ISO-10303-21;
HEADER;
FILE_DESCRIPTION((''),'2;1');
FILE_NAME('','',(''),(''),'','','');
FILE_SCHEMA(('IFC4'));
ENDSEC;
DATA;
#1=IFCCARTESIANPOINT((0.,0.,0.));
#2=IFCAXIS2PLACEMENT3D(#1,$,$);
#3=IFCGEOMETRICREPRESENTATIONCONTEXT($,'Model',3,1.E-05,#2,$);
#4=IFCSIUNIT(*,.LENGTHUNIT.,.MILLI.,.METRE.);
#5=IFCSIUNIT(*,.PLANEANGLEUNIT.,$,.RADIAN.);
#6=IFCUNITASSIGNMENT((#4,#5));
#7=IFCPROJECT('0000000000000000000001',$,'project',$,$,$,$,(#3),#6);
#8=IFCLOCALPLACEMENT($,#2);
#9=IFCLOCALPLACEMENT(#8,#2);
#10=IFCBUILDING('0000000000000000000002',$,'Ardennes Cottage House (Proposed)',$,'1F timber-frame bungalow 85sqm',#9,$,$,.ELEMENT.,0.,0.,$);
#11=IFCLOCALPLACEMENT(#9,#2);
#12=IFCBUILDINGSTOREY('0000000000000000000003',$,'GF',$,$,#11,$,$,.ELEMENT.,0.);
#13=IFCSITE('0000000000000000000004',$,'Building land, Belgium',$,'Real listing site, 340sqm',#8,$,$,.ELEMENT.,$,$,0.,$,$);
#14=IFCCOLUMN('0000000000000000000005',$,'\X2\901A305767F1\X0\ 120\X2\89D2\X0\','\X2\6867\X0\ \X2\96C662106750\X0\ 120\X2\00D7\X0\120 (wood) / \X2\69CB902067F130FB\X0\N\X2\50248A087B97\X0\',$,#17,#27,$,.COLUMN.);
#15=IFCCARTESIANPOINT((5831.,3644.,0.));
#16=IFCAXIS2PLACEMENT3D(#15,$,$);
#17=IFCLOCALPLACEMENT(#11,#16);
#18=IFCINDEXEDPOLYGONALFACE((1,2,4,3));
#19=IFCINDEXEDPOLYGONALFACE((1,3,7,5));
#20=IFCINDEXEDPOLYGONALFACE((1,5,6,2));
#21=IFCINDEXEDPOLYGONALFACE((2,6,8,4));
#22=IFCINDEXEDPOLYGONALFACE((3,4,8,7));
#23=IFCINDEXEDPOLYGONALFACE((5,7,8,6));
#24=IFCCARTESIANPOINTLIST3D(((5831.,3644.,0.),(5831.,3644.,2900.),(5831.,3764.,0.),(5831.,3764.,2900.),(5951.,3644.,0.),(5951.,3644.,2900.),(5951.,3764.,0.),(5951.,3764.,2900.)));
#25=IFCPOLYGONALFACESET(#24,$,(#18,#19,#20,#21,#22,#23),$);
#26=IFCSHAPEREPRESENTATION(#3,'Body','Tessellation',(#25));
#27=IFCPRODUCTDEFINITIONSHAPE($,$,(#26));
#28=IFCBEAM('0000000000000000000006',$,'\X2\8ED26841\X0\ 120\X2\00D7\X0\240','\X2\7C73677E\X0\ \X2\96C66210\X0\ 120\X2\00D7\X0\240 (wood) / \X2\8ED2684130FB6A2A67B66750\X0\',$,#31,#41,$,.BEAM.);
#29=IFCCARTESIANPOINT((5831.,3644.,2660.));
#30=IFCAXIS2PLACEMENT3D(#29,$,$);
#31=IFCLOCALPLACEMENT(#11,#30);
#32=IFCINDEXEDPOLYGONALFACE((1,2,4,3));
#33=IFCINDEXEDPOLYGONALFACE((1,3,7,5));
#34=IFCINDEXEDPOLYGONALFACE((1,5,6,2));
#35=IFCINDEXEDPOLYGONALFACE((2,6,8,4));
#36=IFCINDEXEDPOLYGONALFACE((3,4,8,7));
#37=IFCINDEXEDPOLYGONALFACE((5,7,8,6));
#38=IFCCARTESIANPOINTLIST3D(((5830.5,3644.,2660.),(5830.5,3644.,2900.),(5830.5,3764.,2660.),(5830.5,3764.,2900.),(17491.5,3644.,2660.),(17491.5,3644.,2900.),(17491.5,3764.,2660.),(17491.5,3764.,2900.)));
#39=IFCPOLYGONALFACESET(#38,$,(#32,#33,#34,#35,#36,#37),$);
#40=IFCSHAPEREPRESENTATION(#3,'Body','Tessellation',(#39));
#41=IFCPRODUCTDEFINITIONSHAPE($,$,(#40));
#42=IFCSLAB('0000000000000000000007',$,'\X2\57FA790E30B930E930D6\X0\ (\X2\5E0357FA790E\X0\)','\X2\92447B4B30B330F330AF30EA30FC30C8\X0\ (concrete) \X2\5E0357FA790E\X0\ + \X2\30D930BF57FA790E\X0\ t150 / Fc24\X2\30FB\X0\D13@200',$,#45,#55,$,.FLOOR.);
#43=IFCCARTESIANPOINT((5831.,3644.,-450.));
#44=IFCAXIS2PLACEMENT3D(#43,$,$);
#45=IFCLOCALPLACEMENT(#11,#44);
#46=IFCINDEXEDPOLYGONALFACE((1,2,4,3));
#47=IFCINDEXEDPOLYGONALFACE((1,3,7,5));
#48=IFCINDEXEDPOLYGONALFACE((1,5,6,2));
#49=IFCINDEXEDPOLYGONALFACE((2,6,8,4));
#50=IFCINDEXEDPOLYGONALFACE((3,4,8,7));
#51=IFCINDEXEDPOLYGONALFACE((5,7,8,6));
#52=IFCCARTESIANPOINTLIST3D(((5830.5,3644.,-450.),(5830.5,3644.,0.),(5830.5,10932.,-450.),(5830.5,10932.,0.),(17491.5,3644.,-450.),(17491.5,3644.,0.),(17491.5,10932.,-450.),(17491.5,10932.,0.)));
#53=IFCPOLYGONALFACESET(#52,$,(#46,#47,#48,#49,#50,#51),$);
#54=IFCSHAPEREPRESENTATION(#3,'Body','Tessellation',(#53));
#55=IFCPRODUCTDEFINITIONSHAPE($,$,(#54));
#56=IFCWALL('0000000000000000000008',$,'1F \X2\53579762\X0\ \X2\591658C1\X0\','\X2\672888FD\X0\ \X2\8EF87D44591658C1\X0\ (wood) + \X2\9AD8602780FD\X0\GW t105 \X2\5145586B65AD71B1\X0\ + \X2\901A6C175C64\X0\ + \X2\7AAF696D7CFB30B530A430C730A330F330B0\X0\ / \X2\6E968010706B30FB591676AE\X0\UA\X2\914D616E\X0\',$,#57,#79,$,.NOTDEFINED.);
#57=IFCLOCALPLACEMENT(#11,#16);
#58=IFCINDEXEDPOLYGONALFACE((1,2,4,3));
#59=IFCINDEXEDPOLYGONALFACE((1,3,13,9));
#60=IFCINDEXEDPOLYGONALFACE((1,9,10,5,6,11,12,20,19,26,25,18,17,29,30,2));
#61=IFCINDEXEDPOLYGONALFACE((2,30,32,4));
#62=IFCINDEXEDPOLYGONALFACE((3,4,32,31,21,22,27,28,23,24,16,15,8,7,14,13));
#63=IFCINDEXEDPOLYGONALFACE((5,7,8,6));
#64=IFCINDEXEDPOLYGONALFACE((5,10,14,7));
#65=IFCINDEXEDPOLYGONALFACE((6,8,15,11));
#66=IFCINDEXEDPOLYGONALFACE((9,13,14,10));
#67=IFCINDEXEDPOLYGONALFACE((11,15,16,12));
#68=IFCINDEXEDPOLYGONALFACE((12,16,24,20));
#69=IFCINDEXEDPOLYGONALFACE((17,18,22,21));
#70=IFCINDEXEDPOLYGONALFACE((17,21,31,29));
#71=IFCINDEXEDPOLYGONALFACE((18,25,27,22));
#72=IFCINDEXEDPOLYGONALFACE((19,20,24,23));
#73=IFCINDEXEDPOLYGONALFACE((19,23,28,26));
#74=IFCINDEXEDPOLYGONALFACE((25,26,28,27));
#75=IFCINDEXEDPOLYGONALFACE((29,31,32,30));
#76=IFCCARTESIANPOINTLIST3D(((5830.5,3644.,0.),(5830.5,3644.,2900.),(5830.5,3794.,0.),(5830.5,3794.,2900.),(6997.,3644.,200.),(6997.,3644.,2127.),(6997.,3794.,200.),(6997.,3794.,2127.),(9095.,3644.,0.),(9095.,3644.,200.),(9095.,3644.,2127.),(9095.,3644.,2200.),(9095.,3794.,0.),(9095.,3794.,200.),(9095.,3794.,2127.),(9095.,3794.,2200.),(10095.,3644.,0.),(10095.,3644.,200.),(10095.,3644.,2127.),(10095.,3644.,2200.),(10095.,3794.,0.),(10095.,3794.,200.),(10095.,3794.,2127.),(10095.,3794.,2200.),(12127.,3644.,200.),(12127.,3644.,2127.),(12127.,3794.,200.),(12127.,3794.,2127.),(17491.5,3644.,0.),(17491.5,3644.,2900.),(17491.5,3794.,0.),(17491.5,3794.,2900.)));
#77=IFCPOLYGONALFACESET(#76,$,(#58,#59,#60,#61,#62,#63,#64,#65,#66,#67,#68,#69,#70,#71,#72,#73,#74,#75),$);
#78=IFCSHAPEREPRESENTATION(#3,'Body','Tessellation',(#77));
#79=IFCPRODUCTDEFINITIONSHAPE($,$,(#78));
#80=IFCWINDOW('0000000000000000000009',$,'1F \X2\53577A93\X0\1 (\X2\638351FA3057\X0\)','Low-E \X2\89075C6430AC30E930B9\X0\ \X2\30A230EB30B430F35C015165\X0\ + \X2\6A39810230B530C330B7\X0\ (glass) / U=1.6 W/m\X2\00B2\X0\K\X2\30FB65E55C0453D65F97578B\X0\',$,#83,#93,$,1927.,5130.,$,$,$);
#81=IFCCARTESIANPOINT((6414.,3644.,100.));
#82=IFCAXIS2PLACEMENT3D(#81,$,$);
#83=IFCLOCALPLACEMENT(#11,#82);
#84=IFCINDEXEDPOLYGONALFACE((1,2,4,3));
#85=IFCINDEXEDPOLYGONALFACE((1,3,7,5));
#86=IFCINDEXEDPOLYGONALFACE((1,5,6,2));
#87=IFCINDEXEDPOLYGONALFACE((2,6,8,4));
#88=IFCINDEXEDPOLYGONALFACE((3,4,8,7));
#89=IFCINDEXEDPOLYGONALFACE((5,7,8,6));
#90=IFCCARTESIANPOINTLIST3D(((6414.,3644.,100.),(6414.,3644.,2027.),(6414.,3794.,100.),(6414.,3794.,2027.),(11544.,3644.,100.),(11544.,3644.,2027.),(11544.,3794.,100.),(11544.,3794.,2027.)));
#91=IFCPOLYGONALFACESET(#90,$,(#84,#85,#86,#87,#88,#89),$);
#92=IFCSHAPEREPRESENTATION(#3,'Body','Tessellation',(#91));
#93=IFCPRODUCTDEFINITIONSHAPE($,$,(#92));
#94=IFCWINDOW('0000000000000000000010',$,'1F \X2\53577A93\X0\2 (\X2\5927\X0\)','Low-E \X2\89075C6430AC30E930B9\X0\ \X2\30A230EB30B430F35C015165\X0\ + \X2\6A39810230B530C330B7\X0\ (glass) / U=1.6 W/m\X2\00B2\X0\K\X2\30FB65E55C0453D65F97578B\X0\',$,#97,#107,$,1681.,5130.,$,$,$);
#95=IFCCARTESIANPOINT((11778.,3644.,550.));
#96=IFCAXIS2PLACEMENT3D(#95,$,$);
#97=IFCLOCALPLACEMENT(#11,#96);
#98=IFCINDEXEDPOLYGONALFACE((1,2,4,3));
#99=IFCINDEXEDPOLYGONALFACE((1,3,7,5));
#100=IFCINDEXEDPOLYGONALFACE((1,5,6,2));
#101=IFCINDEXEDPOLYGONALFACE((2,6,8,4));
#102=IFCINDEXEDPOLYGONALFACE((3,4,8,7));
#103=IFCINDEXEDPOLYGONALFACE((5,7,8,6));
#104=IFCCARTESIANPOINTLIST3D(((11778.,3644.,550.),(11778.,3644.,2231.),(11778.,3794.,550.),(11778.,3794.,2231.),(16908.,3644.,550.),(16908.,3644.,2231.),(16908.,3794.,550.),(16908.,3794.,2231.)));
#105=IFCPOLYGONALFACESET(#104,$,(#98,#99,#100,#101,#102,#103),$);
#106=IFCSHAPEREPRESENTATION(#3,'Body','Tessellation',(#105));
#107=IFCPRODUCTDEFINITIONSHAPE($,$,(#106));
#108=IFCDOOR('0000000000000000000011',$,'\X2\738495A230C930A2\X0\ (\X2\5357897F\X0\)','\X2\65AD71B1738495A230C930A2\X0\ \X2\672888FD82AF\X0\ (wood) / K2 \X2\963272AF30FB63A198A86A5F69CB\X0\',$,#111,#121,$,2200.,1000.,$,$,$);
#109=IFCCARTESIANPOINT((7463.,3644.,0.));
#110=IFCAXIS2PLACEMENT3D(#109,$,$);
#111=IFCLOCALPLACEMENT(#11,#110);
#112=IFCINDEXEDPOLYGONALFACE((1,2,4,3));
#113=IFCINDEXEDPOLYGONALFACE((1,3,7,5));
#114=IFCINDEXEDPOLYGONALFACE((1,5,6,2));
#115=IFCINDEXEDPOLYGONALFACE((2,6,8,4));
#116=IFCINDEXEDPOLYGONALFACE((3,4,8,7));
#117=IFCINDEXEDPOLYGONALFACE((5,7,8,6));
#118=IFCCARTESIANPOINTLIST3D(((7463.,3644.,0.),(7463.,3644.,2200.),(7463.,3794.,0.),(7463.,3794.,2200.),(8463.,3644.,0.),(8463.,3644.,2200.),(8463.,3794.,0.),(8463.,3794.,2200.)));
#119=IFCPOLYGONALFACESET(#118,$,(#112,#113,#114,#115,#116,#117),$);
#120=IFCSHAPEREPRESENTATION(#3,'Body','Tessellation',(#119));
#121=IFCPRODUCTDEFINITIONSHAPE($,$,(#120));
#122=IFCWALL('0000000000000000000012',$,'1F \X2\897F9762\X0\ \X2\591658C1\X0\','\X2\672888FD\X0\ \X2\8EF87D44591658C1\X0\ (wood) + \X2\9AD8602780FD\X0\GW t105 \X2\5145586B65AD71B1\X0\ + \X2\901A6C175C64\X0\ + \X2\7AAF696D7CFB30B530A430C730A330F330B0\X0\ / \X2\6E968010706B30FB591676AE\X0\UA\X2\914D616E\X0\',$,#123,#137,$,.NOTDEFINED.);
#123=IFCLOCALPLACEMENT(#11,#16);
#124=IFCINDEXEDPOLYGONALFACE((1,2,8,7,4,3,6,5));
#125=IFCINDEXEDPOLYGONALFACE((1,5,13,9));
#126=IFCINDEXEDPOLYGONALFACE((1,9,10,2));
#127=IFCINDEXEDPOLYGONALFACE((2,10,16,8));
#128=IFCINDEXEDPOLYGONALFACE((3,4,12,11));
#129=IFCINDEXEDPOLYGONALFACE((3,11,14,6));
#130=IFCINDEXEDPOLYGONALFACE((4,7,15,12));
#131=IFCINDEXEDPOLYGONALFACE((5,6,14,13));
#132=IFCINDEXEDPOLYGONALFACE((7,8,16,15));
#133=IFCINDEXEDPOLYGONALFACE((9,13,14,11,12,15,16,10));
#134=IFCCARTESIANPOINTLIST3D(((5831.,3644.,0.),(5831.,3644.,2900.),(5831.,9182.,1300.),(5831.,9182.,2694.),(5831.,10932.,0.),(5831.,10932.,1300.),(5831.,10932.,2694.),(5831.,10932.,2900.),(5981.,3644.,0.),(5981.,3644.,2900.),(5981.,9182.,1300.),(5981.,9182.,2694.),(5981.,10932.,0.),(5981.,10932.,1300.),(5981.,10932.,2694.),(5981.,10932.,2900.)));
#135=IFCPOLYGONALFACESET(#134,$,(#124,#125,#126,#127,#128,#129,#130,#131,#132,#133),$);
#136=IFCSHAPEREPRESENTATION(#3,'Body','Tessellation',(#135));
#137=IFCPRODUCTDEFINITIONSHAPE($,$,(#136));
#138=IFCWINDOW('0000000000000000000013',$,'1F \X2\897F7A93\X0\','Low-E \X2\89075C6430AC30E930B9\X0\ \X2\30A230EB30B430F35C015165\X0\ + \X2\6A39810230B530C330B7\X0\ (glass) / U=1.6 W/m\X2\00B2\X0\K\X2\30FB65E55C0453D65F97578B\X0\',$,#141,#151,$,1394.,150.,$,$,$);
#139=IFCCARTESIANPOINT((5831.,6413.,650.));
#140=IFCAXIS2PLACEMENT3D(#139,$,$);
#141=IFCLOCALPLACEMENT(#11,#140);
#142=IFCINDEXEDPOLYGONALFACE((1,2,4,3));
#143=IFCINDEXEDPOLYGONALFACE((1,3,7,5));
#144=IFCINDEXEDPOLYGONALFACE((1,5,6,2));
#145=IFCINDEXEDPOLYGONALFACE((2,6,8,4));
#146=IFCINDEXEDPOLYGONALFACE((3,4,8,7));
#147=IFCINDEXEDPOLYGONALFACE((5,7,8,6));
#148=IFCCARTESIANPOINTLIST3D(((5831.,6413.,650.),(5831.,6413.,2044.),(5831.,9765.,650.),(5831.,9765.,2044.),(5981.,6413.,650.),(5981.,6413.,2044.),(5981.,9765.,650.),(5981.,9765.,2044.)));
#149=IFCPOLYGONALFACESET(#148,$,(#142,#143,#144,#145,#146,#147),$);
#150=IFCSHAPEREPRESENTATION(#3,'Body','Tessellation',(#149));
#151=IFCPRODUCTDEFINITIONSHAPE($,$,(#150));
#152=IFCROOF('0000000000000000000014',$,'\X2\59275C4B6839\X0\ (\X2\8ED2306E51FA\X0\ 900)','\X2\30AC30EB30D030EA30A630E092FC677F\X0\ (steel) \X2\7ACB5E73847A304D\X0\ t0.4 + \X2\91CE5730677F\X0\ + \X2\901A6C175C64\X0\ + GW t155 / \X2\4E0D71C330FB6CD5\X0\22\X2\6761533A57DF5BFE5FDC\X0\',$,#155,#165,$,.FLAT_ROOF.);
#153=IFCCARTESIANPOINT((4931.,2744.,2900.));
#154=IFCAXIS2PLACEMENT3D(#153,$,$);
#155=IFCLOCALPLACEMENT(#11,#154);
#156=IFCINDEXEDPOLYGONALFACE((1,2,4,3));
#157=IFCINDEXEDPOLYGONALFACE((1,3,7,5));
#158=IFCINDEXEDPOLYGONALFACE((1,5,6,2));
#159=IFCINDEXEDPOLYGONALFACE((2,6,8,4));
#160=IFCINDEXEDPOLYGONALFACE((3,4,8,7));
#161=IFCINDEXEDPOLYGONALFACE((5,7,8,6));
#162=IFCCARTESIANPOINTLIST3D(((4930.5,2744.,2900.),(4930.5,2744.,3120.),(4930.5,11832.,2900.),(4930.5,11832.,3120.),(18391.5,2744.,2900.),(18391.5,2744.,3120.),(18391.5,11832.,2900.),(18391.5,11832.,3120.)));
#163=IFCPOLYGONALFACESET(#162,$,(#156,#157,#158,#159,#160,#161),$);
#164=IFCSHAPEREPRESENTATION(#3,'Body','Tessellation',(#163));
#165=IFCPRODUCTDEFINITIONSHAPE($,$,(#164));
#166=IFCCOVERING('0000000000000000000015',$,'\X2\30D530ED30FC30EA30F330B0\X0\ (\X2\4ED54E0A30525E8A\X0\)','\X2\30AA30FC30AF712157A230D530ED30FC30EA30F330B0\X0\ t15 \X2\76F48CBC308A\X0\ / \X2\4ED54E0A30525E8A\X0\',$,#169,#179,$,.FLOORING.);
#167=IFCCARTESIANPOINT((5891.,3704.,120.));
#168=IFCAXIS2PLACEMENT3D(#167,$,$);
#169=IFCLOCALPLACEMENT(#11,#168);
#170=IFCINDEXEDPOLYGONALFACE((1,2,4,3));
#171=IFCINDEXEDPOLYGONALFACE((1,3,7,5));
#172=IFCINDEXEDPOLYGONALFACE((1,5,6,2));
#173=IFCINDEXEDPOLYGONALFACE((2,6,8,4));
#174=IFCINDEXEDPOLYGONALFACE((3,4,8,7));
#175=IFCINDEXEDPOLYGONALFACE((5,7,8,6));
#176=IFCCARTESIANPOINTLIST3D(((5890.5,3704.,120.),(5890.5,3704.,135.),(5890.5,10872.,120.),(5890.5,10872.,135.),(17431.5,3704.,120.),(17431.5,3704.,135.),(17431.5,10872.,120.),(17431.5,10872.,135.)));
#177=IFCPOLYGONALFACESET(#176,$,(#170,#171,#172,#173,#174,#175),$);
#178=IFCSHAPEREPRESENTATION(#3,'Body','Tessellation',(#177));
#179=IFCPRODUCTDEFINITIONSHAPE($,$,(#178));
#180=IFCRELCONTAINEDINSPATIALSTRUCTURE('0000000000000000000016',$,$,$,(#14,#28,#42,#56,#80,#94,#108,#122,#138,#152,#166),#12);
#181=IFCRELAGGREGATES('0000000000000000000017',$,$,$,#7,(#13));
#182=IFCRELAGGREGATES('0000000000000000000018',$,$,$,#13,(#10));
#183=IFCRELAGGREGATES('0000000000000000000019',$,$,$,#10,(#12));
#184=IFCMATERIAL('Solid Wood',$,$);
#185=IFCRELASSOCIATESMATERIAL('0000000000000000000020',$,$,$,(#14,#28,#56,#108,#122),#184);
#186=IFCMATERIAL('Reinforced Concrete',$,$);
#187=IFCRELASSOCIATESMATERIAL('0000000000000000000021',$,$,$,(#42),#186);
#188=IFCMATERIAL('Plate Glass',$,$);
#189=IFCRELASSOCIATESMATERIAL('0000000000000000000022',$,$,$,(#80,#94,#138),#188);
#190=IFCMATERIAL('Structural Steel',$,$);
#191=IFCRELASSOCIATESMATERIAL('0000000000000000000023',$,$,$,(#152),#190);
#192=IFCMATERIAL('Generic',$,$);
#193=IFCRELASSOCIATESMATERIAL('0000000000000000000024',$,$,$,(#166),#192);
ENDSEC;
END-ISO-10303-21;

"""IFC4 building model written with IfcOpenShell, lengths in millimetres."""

from ifc_helpers import new_model, si_unit, frame, frame_2d, origin, place, context, project, spatial, rectangle, extrude, material, element, fill, save


model = new_model("IFC4")

# Units and contexts
model_context = context("Model", 3, precision=1e-05, world=origin())
ifc_project = project(units=[si_unit("LENGTHUNIT", "METRE", prefix="MILLI"), si_unit("PLANEANGLEUNIT", "RADIAN")], contexts=[model_context])

# Site, building, storey
site_placement = place(None, origin())
site = spatial("IfcSite", under=ifc_project, at=site_placement, Name="Building land, Belgium", ObjectType="Real listing site, 340sqm", CompositionType="ELEMENT", RefElevation=0.0)
building_placement = place(site_placement, origin())
building = spatial("IfcBuilding", under=site, at=building_placement, Name="Ardennes Cottage House (Proposed)", ObjectType="1F timber-frame bungalow 85sqm", CompositionType="ELEMENT", ElevationOfRefHeight=0.0, ElevationOfTerrain=0.0)
storey_placement = place(building_placement, origin())
storey = spatial("IfcBuildingStorey", under=building, at=storey_placement, Name="GF", CompositionType="ELEMENT", Elevation=0.0)

# Column
ifc_material_1 = material(Name="Solid Wood")
column_1_placement = place(storey_placement, frame((5831.0, 3644.0, 0.0)))
element("IfcColumn", 1, at=column_1_placement, inside=storey, material=ifc_material_1, Name="通し柱 120角", Description="桧 集成材 120×120 (wood) / 構造柱・N値計算", PredefinedType="COLUMN", context=model_context, shape_type="SweptSolid", body=[
    extrude(rectangle(XDim=120.0, YDim=120.0, at=frame_2d((60.0, 60.0))), frame((5831.0, 3644.0, 0.0)), (0.0, 0.0, 1.0), 2900.0),
])

# Beam
beam_1_placement = place(storey_placement, frame((5831.0, 3644.0, 2660.0)))
element("IfcBeam", 2, at=beam_1_placement, inside=storey, material=ifc_material_1, Name="軒桁 120×240", Description="米松 集成 120×240 (wood) / 軒桁・横架材", PredefinedType="BEAM", context=model_context, shape_type="SweptSolid", body=[
    extrude(rectangle(XDim=11661.0, YDim=120.0, at=frame_2d((5830.0, 60.0))), frame((5831.0, 3644.0, 2660.0)), (0.0, 0.0, 1.0), 240.0),
])

# Slab
ifc_material_2 = material(Name="Reinforced Concrete")
slab_1_placement = place(storey_placement, frame((5831.0, 3644.0, -450.0)))
element("IfcSlab", 3, at=slab_1_placement, inside=storey, material=ifc_material_2, Name="基礎スラブ (布基礎)", Description="鉄筋コンクリート (concrete) 布基礎 + ベタ基礎 t150 / Fc24・D13@200", PredefinedType="FLOOR", context=model_context, shape_type="SweptSolid", body=[
    extrude(rectangle(XDim=11661.0, YDim=7288.0, at=frame_2d((5830.0, 3644.0))), frame((5831.0, 3644.0, -450.0)), (0.0, 0.0, 1.0), 450.0),
])

# Wall, openings, windows, door
wall_1_placement = place(storey_placement, frame((5831.0, 3644.0, 0.0)))
wall_1 = element("IfcWall", 4, at=wall_1_placement, inside=storey, material=ifc_material_1, Name="1F 南面 外壁", Description="木製 軸組外壁 (wood) + 高性能GW t105 充填断熱 + 通気層 + 窯業系サイディング / 準耐火・外皮UA配慮", PredefinedType="NOTDEFINED", context=model_context, shape_type="SweptSolid", body=[
    extrude(rectangle(XDim=11661.0, YDim=150.0, at=frame_2d((5830.0, 75.0))), frame((5831.0, 3644.0, 0.0)), (0.0, 0.0, 1.0), 2900.0),
])
opening_1_placement = place(storey_placement, frame((6414.0, 3644.0, 100.0)))
opening_1 = element("IfcOpeningElement", 5, at=opening_1_placement, cuts=wall_1, PredefinedType="NOTDEFINED", context=model_context, shape_type="SweptSolid", body=[
    extrude(rectangle(XDim=5130.0, YDim=150.0, at=frame_2d((2565.0, 75.0))), frame((6414.0, 3644.0, 100.0)), (0.0, 0.0, 1.0), 1927.0),
])
opening_2_placement = place(storey_placement, frame((11778.0, 3644.0, 550.0)))
opening_2 = element("IfcOpeningElement", 6, at=opening_2_placement, cuts=wall_1, PredefinedType="NOTDEFINED", context=model_context, shape_type="SweptSolid", body=[
    extrude(rectangle(XDim=5130.0, YDim=150.0, at=frame_2d((2565.0, 75.0))), frame((11778.0, 3644.0, 550.0)), (0.0, 0.0, 1.0), 1681.0),
])
opening_3_placement = place(storey_placement, frame((7463.0, 3644.0, 0.0)))
opening_3 = element("IfcOpeningElement", 7, at=opening_3_placement, cuts=wall_1, PredefinedType="NOTDEFINED", context=model_context, shape_type="SweptSolid", body=[
    extrude(rectangle(XDim=1000.0, YDim=150.0, at=frame_2d((500.0, 75.0))), frame((7463.0, 3644.0, 0.0)), (0.0, 0.0, 1.0), 2200.0),
])
ifc_material_3 = material(Name="Plate Glass")
window_1_placement = place(storey_placement, frame((6414.0, 3644.0, 100.0)))
window_1 = element("IfcWindow", 8, at=window_1_placement, inside=storey, material=ifc_material_3, Name="1F 南窓1 (掃出し)", Description="Low-E 複層ガラス アルゴン封入 + 樹脂サッシ (glass) / U=1.6 W/m²K・日射取得型", OverallHeight=1927.0, OverallWidth=5130.0, context=model_context, shape_type="SweptSolid", body=[
    extrude(rectangle(XDim=5130.0, YDim=150.0, at=frame_2d((2565.0, 75.0))), frame((6414.0, 3644.0, 100.0)), (0.0, 0.0, 1.0), 1927.0),
])
fill(opening_1, window_1)
window_2_placement = place(storey_placement, frame((11778.0, 3644.0, 550.0)))
window_2 = element("IfcWindow", 9, at=window_2_placement, inside=storey, material=ifc_material_3, Name="1F 南窓2 (大)", Description="Low-E 複層ガラス アルゴン封入 + 樹脂サッシ (glass) / U=1.6 W/m²K・日射取得型", OverallHeight=1681.0, OverallWidth=5130.0, context=model_context, shape_type="SweptSolid", body=[
    extrude(rectangle(XDim=5130.0, YDim=150.0, at=frame_2d((2565.0, 75.0))), frame((11778.0, 3644.0, 550.0)), (0.0, 0.0, 1.0), 1681.0),
])
fill(opening_2, window_2)
door_placement = place(storey_placement, frame((7463.0, 3644.0, 0.0)))
door = element("IfcDoor", 10, at=door_placement, inside=storey, material=ifc_material_1, Name="玄関ドア (南西)", Description="断熱玄関ドア 木製芯 (wood) / K2 防犯・採風機構", OverallHeight=2200.0, OverallWidth=1000.0, context=model_context, shape_type="SweptSolid", body=[
    extrude(rectangle(XDim=1000.0, YDim=150.0, at=frame_2d((500.0, 75.0))), frame((7463.0, 3644.0, 0.0)), (0.0, 0.0, 1.0), 2200.0),
])
fill(opening_3, door)

# Wall, opening, window
wall_2_placement = place(storey_placement, frame((5831.0, 3644.0, 0.0)))
wall_2 = element("IfcWall", 11, at=wall_2_placement, inside=storey, material=ifc_material_1, Name="1F 西面 外壁", Description="木製 軸組外壁 (wood) + 高性能GW t105 充填断熱 + 通気層 + 窯業系サイディング / 準耐火・外皮UA配慮", PredefinedType="NOTDEFINED", context=model_context, shape_type="SweptSolid", body=[
    extrude(rectangle(XDim=150.0, YDim=7288.0, at=frame_2d((75.0, 3644.0))), frame((5831.0, 3644.0, 0.0)), (0.0, 0.0, 1.0), 2900.0),
])
opening_4_placement = place(storey_placement, frame((5831.0, 6413.0, 650.0)))
opening_4 = element("IfcOpeningElement", 12, at=opening_4_placement, cuts=wall_2, PredefinedType="NOTDEFINED", context=model_context, shape_type="SweptSolid", body=[
    extrude(rectangle(XDim=150.0, YDim=3352.0, at=frame_2d((75.0, 1676.0))), frame((5831.0, 6413.0, 650.0)), (0.0, 0.0, 1.0), 1394.0),
])
window_3_placement = place(storey_placement, frame((5831.0, 6413.0, 650.0)))
window_3 = element("IfcWindow", 13, at=window_3_placement, inside=storey, material=ifc_material_3, Name="1F 西窓", Description="Low-E 複層ガラス アルゴン封入 + 樹脂サッシ (glass) / U=1.6 W/m²K・日射取得型", OverallHeight=1394.0, OverallWidth=150.0, context=model_context, shape_type="SweptSolid", body=[
    extrude(rectangle(XDim=150.0, YDim=3352.0, at=frame_2d((75.0, 1676.0))), frame((5831.0, 6413.0, 650.0)), (0.0, 0.0, 1.0), 1394.0),
])
fill(opening_4, window_3)

# Roof
ifc_material_4 = material(Name="Structural Steel")
roof_placement = place(storey_placement, frame((4931.0, 2744.0, 2900.0)))
element("IfcRoof", 14, at=roof_placement, inside=storey, material=ifc_material_4, Name="大屋根 (軒の出 900)", Description="ガルバリウム鋼板 (steel) 立平葺き t0.4 + 野地板 + 通気層 + GW t155 / 不燃・法22条区域対応", PredefinedType="FLAT_ROOF", context=model_context, shape_type="SweptSolid", body=[
    extrude(rectangle(XDim=13461.0, YDim=9088.0, at=frame_2d((6730.0, 4544.0))), frame((4931.0, 2744.0, 2900.0)), (0.0, 0.0, 1.0), 220.0),
])

# Covering
ifc_material_5 = material(Name="Generic")
covering_1_placement = place(storey_placement, frame((5891.0, 3704.0, 120.0)))
element("IfcCovering", 15, at=covering_1_placement, inside=storey, material=ifc_material_5, Name="フローリング (仕上げ床)", Description="オーク無垢フローリング t15 直貼り / 仕上げ床", PredefinedType="FLOORING", context=model_context, shape_type="SweptSolid", body=[
    extrude(rectangle(XDim=11541.0, YDim=7168.0, at=frame_2d((5770.0, 3584.0))), frame((5891.0, 3704.0, 120.0)), (0.0, 0.0, 1.0), 15.0),
])

save(model, "model.ifc")
